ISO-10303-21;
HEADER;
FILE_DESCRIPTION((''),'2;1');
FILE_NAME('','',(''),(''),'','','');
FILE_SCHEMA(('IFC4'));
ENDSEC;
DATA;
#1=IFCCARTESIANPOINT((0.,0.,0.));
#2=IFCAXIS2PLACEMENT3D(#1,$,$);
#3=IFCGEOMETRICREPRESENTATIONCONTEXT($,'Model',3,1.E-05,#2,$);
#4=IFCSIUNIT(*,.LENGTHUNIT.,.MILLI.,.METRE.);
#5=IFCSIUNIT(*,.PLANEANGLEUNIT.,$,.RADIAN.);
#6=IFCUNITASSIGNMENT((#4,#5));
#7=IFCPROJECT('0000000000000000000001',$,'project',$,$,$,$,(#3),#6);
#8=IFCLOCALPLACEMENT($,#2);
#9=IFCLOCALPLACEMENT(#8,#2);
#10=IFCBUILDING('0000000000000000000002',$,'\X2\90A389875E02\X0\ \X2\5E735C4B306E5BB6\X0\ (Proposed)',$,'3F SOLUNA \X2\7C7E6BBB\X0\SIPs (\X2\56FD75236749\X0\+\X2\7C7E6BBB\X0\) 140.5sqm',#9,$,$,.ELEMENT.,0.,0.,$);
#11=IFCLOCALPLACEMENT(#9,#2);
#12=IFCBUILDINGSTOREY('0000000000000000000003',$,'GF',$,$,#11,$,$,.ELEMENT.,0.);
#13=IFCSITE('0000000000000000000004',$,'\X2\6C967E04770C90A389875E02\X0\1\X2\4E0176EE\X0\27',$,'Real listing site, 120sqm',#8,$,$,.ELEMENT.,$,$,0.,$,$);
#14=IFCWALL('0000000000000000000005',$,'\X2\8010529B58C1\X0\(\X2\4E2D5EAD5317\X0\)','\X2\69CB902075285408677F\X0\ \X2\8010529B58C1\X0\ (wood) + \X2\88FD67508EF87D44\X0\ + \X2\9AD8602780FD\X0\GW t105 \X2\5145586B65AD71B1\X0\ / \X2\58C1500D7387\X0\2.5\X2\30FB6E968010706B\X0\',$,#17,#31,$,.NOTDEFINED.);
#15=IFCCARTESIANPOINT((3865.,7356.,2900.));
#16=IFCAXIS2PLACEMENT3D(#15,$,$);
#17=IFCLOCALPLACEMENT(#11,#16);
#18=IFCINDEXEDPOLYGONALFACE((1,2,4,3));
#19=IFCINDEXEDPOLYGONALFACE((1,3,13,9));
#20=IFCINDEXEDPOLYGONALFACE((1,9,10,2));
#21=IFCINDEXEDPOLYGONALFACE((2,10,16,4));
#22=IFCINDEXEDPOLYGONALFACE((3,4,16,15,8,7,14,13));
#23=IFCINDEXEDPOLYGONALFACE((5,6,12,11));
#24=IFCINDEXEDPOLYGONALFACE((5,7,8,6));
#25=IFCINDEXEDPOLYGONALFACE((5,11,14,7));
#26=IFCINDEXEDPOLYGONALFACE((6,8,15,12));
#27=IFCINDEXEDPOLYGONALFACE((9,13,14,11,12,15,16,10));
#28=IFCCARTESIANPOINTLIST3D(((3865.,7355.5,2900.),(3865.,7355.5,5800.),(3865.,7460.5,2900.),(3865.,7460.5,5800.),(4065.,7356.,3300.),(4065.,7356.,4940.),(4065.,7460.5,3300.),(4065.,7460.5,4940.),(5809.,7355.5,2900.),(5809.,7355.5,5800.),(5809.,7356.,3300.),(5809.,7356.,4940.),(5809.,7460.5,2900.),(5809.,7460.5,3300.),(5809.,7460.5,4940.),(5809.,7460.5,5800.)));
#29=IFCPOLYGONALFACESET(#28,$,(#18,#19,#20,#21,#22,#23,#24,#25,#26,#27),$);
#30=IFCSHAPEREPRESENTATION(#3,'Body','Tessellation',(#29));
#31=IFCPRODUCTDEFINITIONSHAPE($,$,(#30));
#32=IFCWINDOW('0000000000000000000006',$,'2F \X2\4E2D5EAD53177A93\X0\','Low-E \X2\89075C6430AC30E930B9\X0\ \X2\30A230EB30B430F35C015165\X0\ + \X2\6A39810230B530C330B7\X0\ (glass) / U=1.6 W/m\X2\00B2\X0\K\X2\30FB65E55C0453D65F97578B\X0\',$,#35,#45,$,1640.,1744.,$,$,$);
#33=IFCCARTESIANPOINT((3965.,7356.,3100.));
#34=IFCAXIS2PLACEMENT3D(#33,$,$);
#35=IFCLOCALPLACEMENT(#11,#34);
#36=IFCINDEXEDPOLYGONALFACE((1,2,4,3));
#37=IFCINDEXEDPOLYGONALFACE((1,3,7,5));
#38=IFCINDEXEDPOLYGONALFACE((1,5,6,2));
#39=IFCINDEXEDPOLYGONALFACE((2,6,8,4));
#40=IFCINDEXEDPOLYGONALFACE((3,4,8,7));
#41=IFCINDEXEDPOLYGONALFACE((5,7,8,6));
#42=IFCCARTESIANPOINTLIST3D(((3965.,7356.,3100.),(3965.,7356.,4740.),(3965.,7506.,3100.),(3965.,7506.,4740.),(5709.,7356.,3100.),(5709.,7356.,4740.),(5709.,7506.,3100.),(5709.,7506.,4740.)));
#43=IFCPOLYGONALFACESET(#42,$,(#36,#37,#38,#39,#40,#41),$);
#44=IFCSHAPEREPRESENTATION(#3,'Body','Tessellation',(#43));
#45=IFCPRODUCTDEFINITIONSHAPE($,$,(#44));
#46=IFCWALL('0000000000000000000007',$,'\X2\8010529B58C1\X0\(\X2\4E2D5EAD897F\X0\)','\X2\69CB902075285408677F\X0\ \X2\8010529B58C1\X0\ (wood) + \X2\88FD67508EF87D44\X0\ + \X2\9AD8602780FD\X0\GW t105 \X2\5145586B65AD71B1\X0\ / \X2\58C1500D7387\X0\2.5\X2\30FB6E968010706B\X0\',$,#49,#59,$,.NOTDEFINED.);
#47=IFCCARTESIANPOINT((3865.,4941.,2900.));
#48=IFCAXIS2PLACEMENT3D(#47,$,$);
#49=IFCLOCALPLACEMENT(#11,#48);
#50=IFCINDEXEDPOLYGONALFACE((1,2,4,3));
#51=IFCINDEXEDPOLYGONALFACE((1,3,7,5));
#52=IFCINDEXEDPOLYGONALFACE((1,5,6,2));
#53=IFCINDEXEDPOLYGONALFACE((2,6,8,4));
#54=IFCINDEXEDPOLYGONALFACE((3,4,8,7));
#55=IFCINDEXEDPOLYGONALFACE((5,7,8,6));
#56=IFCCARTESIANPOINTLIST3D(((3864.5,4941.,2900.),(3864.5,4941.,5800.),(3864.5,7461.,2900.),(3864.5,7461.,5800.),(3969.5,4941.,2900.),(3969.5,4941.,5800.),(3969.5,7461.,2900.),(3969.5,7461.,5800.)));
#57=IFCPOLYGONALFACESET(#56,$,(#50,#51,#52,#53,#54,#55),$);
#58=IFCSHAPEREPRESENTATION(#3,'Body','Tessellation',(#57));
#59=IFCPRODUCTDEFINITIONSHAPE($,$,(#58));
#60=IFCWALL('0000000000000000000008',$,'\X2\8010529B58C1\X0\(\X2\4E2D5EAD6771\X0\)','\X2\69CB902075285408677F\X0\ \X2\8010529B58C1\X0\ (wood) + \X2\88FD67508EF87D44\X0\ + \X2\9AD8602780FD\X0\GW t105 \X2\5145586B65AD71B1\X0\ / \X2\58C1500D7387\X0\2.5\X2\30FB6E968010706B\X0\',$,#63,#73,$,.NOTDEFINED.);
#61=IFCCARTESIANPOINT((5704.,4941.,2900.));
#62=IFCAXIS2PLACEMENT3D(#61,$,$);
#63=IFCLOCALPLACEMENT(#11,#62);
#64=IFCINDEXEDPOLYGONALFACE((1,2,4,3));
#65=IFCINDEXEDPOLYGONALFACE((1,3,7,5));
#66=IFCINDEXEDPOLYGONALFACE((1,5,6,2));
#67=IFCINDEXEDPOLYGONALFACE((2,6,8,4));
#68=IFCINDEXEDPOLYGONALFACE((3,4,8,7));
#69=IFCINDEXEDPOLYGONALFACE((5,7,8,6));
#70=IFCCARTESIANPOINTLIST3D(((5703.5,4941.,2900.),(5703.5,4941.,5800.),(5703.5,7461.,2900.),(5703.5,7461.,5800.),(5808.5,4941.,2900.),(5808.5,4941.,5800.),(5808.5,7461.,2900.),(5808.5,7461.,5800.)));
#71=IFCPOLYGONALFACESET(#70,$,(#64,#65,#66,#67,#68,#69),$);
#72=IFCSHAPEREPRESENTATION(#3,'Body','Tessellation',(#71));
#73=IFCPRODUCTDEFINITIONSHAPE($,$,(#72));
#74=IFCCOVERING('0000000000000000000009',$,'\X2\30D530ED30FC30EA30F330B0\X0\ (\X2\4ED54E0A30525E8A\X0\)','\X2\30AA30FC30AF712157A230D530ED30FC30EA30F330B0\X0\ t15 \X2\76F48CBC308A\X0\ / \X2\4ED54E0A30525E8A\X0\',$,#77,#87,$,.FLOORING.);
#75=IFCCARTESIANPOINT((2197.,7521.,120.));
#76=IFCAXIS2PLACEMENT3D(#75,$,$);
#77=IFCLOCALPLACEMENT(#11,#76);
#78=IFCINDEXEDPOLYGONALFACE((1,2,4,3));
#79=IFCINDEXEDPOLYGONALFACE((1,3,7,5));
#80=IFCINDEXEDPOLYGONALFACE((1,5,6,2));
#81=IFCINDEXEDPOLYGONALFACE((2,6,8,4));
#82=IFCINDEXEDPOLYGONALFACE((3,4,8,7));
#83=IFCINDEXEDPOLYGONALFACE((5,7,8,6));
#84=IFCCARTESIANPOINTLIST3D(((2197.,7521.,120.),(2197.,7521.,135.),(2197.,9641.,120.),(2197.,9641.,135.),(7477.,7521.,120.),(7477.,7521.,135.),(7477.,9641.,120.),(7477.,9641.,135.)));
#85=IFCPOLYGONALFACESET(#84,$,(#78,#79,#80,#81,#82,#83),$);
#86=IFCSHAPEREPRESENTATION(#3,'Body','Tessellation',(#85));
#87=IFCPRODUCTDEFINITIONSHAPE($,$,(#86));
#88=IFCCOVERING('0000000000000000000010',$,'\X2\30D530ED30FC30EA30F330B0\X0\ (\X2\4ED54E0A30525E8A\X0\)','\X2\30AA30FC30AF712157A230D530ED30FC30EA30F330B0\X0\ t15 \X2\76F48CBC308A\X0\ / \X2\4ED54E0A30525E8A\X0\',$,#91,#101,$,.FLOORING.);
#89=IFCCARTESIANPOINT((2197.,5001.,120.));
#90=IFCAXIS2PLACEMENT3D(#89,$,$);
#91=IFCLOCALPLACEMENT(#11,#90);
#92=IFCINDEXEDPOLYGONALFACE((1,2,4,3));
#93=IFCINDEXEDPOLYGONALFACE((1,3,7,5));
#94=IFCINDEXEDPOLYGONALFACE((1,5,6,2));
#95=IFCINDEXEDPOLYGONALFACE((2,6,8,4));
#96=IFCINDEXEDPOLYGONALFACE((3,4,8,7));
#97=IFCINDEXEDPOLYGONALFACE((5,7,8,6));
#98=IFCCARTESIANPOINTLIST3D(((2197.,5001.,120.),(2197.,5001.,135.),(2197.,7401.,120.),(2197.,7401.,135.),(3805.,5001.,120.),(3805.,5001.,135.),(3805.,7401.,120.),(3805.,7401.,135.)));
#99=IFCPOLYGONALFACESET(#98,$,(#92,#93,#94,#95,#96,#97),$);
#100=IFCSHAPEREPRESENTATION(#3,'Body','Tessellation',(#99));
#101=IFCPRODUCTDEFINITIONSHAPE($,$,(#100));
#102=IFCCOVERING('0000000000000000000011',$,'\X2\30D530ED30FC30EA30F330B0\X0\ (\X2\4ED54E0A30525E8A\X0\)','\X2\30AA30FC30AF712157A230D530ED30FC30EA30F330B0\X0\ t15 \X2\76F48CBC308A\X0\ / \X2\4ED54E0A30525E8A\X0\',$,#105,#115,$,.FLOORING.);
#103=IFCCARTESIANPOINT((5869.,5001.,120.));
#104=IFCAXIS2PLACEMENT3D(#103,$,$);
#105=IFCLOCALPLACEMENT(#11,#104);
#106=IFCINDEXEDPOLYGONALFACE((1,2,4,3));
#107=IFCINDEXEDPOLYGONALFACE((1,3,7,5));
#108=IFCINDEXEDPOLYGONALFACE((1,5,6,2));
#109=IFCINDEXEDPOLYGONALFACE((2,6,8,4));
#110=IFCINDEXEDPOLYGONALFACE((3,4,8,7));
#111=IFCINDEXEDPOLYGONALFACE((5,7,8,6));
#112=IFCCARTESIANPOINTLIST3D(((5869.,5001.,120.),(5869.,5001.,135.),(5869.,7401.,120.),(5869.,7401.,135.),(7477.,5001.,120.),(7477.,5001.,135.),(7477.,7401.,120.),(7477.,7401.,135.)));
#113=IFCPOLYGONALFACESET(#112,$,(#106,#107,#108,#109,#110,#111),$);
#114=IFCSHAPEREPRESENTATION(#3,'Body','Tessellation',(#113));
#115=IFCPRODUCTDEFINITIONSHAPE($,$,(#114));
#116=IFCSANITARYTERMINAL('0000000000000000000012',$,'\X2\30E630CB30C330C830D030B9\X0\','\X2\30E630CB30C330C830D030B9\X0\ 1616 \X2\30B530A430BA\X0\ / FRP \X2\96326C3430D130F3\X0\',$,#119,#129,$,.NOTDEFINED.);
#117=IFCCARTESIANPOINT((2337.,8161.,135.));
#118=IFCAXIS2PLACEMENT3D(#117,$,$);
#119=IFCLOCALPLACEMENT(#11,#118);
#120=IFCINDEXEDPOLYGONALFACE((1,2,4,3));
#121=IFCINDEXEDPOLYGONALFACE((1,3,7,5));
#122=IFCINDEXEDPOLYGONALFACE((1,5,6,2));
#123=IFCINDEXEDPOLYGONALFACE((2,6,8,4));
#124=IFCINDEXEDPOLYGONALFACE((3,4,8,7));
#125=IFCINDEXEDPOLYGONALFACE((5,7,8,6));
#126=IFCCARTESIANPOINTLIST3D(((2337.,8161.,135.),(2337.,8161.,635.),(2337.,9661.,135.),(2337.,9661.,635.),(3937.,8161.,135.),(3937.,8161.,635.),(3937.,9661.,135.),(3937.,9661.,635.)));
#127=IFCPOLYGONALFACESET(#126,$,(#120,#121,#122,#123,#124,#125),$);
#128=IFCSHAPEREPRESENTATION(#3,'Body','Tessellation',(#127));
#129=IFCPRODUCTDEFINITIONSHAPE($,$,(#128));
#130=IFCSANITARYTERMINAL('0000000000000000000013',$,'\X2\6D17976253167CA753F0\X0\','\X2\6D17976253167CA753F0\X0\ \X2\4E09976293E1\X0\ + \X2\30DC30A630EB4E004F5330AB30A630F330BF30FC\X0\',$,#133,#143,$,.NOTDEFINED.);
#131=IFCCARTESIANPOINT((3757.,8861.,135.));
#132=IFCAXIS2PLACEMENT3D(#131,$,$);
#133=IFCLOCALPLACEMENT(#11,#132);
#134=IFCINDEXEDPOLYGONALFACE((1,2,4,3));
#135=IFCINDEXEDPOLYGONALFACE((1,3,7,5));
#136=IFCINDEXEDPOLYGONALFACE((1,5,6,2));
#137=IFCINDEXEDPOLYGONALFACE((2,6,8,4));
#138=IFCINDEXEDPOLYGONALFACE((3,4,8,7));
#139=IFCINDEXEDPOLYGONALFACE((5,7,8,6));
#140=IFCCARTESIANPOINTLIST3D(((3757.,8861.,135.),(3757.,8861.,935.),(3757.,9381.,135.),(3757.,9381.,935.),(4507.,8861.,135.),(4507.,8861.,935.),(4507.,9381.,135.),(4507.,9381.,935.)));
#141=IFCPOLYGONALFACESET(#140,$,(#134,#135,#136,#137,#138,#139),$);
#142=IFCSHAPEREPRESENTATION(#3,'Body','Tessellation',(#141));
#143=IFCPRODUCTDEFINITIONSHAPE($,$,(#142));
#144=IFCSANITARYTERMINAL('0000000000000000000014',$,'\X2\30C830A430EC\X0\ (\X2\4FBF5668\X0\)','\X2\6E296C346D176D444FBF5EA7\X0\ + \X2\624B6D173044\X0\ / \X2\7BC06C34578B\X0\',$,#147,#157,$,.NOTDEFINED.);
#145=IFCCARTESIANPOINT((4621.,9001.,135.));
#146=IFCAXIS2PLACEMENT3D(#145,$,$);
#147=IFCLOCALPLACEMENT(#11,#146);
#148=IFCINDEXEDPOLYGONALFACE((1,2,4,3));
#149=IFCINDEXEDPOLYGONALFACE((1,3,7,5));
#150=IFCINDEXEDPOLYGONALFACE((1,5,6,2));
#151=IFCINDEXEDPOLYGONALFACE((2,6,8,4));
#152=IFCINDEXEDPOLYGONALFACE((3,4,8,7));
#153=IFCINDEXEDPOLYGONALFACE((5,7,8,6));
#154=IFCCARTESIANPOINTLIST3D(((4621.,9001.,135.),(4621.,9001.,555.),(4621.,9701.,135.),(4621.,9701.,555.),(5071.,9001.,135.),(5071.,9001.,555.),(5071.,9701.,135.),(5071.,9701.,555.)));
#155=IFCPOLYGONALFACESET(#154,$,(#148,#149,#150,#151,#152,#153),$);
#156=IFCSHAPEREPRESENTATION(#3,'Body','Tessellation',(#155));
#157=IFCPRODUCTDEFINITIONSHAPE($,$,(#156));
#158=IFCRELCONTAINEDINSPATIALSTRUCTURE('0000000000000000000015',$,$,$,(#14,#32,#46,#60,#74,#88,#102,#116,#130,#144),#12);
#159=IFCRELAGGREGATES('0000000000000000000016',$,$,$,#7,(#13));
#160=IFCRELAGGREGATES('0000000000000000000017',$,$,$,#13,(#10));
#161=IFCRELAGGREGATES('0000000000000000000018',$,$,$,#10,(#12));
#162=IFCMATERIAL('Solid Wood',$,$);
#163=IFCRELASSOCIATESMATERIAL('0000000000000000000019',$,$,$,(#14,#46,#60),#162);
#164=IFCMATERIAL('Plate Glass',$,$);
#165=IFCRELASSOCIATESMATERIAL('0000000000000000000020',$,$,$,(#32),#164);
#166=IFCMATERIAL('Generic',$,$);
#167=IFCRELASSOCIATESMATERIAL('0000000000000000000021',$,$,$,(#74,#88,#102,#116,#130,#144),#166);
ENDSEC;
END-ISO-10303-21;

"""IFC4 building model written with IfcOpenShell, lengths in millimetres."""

from ifc_helpers import new_model, si_unit, frame, frame_2d, origin, place, context, project, spatial, rectangle, extrude, material, element, fill, save


model = new_model("IFC4")

# Units and contexts
model_context = context("Model", 3, precision=1e-05, world=origin())
ifc_project = project(units=[si_unit("LENGTHUNIT", "METRE", prefix="MILLI"), si_unit("PLANEANGLEUNIT", "RADIAN")], contexts=[model_context])

# Site, building, storey
site_placement = place(None, origin())
site = spatial("IfcSite", under=ifc_project, at=site_placement, Name="沖縄県那覇市1丁目27", ObjectType="Real listing site, 120sqm", CompositionType="ELEMENT", RefElevation=0.0)
building_placement = place(site_placement, origin())
building = spatial("IfcBuilding", under=site, at=building_placement, Name="那覇市 平屋の家 (Proposed)", ObjectType="3F SOLUNA 籾殻SIPs (国産杉+籾殻) 140.5sqm", CompositionType="ELEMENT", ElevationOfRefHeight=0.0, ElevationOfTerrain=0.0)
storey_placement = place(building_placement, origin())
storey = spatial("IfcBuildingStorey", under=building, at=storey_placement, Name="GF", CompositionType="ELEMENT", Elevation=0.0)

# Shared definitions
ifc_material_1 = material(Name="Solid Wood")

# Shared definitions
ifc_material_2 = material(Name="Plate Glass")

# Wall, opening, window
wall_1_placement = place(storey_placement, frame((3865.0, 7356.0, 2900.0)))
wall_1 = element("IfcWall", 1, at=wall_1_placement, inside=storey, material=ifc_material_1, Name="耐力壁(中庭北)", Description="構造用合板 耐力壁 (wood) + 製材軸組 + 高性能GW t105 充填断熱 / 壁倍率2.5・準耐火", PredefinedType="NOTDEFINED", context=model_context, shape_type="SweptSolid", body=[
    extrude(rectangle(XDim=1944.0, YDim=105.0, at=frame_2d((972.0, 52.0))), frame((3865.0, 7356.0, 2900.0)), (0.0, 0.0, 1.0), 2900.0),
])
opening_1_placement = place(storey_placement, frame((3965.0, 7356.0, 3100.0)))
opening_1 = element("IfcOpeningElement", 2, at=opening_1_placement, cuts=wall_1, PredefinedType="NOTDEFINED", context=model_context, shape_type="SweptSolid", body=[
    extrude(rectangle(XDim=1744.0, YDim=150.0, at=frame_2d((872.0, 75.0))), frame((3965.0, 7356.0, 3100.0)), (0.0, 0.0, 1.0), 1640.0),
])
window_1_placement = place(storey_placement, frame((3965.0, 7356.0, 3100.0)))
window_1 = element("IfcWindow", 3, at=window_1_placement, inside=storey, material=ifc_material_2, Name="2F 中庭北窓", Description="Low-E 複層ガラス アルゴン封入 + 樹脂サッシ (glass) / U=1.6 W/m²K・日射取得型", OverallHeight=1640.0, OverallWidth=1744.0, context=model_context, shape_type="SweptSolid", body=[
    extrude(rectangle(XDim=1744.0, YDim=150.0, at=frame_2d((872.0, 75.0))), frame((3965.0, 7356.0, 3100.0)), (0.0, 0.0, 1.0), 1640.0),
])
fill(opening_1, window_1)

# Walls
wall_2_placement = place(storey_placement, frame((3865.0, 4941.0, 2900.0)))
element("IfcWall", 4, at=wall_2_placement, inside=storey, material=ifc_material_1, Name="耐力壁(中庭西)", Description="構造用合板 耐力壁 (wood) + 製材軸組 + 高性能GW t105 充填断熱 / 壁倍率2.5・準耐火", PredefinedType="NOTDEFINED", context=model_context, shape_type="SweptSolid", body=[
    extrude(rectangle(XDim=105.0, YDim=2520.0, at=frame_2d((52.0, 1260.0))), frame((3865.0, 4941.0, 2900.0)), (0.0, 0.0, 1.0), 2900.0),
])
wall_3_placement = place(storey_placement, frame((5704.0, 4941.0, 2900.0)))
element("IfcWall", 5, at=wall_3_placement, inside=storey, material=ifc_material_1, Name="耐力壁(中庭東)", Description="構造用合板 耐力壁 (wood) + 製材軸組 + 高性能GW t105 充填断熱 / 壁倍率2.5・準耐火", PredefinedType="NOTDEFINED", context=model_context, shape_type="SweptSolid", body=[
    extrude(rectangle(XDim=105.0, YDim=2520.0, at=frame_2d((52.0, 1260.0))), frame((5704.0, 4941.0, 2900.0)), (0.0, 0.0, 1.0), 2900.0),
])

# Coverings
ifc_material_3 = material(Name="Generic")
covering_1_placement = place(storey_placement, frame((2197.0, 7521.0, 120.0)))
element("IfcCovering", 6, at=covering_1_placement, inside=storey, material=ifc_material_3, Name="フローリング (仕上げ床)", Description="オーク無垢フローリング t15 直貼り / 仕上げ床", PredefinedType="FLOORING", context=model_context, shape_type="SweptSolid", body=[
    extrude(rectangle(XDim=5280.0, YDim=2120.0, at=frame_2d((2640.0, 1060.0))), frame((2197.0, 7521.0, 120.0)), (0.0, 0.0, 1.0), 15.0),
])
covering_2_placement = place(storey_placement, frame((2197.0, 5001.0, 120.0)))
element("IfcCovering", 7, at=covering_2_placement, inside=storey, material=ifc_material_3, Name="フローリング (仕上げ床)", Description="オーク無垢フローリング t15 直貼り / 仕上げ床", PredefinedType="FLOORING", context=model_context, shape_type="SweptSolid", body=[
    extrude(rectangle(XDim=1608.0, YDim=2400.0, at=frame_2d((804.0, 1200.0))), frame((2197.0, 5001.0, 120.0)), (0.0, 0.0, 1.0), 15.0),
])
covering_3_placement = place(storey_placement, frame((5869.0, 5001.0, 120.0)))
element("IfcCovering", 8, at=covering_3_placement, inside=storey, material=ifc_material_3, Name="フローリング (仕上げ床)", Description="オーク無垢フローリング t15 直貼り / 仕上げ床", PredefinedType="FLOORING", context=model_context, shape_type="SweptSolid", body=[
    extrude(rectangle(XDim=1608.0, YDim=2400.0, at=frame_2d((804.0, 1200.0))), frame((5869.0, 5001.0, 120.0)), (0.0, 0.0, 1.0), 15.0),
])

# Sanitary terminals
sanitary_terminal_1_placement = place(storey_placement, frame((2337.0, 8161.0, 135.0)))
element("IfcSanitaryTerminal", 9, at=sanitary_terminal_1_placement, inside=storey, material=ifc_material_3, Name="ユニットバス", Description="ユニットバス 1616 サイズ / FRP 防水パン", PredefinedType="NOTDEFINED", context=model_context, shape_type="SweptSolid", body=[
    extrude(rectangle(XDim=1600.0, YDim=1500.0, at=frame_2d((800.0, 750.0))), frame((2337.0, 8161.0, 135.0)), (0.0, 0.0, 1.0), 500.0),
])
sanitary_terminal_2_placement = place(storey_placement, frame((3757.0, 8861.0, 135.0)))
element("IfcSanitaryTerminal", 10, at=sanitary_terminal_2_placement, inside=storey, material=ifc_material_3, Name="洗面化粧台", Description="洗面化粧台 三面鏡 + ボウル一体カウンター", PredefinedType="NOTDEFINED", context=model_context, shape_type="SweptSolid", body=[
    extrude(rectangle(XDim=750.0, YDim=520.0, at=frame_2d((375.0, 260.0))), frame((3757.0, 8861.0, 135.0)), (0.0, 0.0, 1.0), 800.0),
])
sanitary_terminal_3_placement = place(storey_placement, frame((4621.0, 9001.0, 135.0)))
element("IfcSanitaryTerminal", 11, at=sanitary_terminal_3_placement, inside=storey, material=ifc_material_3, Name="トイレ (便器)", Description="温水洗浄便座 + 手洗い / 節水型", PredefinedType="NOTDEFINED", context=model_context, shape_type="SweptSolid", body=[
    extrude(rectangle(XDim=450.0, YDim=700.0, at=frame_2d((225.0, 350.0))), frame((4621.0, 9001.0, 135.0)), (0.0, 0.0, 1.0), 420.0),
])

save(model, "model.ifc")
